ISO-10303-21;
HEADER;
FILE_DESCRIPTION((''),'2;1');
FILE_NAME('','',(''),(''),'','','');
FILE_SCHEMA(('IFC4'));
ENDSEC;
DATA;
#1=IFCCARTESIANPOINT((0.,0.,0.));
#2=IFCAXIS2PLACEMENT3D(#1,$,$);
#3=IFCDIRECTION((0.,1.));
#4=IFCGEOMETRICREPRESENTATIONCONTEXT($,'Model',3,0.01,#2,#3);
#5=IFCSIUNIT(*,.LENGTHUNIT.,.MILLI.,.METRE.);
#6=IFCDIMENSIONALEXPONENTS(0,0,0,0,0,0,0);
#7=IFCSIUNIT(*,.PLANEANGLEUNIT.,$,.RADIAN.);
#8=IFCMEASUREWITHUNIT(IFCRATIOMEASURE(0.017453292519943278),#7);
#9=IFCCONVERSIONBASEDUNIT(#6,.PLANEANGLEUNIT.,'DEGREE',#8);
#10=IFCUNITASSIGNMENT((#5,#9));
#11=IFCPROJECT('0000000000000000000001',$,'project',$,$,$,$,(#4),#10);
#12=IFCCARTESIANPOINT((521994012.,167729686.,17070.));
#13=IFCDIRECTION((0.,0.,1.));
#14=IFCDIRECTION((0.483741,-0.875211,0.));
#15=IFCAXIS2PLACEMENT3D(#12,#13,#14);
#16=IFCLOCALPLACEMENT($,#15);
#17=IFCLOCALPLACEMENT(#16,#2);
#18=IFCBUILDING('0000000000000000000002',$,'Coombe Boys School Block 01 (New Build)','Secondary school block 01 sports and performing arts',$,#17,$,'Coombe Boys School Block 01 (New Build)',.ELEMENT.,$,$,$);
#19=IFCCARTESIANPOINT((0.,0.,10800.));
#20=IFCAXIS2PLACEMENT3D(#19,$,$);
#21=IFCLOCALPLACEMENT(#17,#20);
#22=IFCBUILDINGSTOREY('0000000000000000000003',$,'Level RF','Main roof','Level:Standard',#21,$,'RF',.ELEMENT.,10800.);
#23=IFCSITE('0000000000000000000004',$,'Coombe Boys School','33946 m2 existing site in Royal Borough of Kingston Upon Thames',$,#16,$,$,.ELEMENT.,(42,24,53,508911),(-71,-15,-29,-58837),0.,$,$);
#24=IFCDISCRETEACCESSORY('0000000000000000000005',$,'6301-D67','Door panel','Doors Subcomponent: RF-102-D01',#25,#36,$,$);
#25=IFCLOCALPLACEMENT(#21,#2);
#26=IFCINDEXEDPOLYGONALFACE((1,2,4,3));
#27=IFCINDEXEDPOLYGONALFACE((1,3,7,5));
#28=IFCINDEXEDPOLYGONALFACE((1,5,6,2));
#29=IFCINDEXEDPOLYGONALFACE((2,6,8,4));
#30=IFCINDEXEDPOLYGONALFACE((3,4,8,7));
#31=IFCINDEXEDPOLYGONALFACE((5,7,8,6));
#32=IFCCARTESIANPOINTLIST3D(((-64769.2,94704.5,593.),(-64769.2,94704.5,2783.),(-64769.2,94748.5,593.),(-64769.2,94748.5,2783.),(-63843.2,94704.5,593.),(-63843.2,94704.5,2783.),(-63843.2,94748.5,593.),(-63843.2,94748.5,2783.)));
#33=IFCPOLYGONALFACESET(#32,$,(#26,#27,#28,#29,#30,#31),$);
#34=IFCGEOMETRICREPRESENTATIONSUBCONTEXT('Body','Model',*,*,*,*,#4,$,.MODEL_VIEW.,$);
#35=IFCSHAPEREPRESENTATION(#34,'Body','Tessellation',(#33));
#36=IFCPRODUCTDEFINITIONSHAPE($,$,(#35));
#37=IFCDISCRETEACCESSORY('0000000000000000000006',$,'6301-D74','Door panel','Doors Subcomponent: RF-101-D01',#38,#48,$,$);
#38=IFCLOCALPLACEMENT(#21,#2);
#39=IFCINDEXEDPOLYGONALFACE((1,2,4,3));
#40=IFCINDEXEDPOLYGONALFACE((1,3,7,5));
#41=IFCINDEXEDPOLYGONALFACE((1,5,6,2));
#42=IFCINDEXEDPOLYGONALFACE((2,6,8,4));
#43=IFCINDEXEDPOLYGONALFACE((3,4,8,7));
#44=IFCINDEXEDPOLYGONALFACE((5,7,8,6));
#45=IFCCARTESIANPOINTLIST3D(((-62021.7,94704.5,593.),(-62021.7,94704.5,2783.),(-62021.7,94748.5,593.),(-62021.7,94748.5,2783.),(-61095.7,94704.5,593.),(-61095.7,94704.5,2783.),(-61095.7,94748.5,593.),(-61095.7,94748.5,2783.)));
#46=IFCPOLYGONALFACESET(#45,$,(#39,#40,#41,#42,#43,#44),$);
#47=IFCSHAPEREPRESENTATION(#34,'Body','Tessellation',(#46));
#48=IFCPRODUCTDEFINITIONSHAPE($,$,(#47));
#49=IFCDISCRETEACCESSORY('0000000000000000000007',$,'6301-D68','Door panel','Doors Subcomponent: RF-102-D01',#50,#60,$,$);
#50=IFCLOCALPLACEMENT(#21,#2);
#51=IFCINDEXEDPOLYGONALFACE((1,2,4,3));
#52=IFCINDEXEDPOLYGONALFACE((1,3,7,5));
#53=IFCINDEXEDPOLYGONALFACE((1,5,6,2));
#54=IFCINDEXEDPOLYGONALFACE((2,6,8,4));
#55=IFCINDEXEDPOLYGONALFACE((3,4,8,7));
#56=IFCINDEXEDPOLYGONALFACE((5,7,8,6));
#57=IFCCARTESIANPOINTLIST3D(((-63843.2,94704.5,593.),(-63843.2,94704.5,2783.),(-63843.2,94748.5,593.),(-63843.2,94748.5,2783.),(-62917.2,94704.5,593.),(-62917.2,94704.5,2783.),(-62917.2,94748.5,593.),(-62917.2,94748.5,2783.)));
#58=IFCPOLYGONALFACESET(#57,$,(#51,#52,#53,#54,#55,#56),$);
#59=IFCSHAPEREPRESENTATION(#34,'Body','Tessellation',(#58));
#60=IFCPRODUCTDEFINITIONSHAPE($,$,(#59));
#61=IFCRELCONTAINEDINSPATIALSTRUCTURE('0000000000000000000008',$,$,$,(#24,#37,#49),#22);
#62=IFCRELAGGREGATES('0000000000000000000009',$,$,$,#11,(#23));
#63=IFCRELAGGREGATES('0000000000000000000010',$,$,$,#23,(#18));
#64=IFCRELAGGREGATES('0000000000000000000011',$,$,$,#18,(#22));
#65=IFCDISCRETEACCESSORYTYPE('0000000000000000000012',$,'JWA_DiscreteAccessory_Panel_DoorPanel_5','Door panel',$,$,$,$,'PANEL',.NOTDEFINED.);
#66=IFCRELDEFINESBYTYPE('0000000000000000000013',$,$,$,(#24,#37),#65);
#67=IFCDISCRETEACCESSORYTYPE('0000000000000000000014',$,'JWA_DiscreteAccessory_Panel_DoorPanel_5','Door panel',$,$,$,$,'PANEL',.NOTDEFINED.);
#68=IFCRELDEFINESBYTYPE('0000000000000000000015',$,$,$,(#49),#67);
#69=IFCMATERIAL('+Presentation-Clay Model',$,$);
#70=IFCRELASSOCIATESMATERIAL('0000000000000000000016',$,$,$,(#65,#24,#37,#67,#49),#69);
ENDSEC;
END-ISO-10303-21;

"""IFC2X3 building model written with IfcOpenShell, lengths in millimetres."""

from ifc_helpers import new_model, entity, si_unit, converted_unit, direction, frame, origin, origin_2d_with_axis, place, context, subcontext, project, spatial, rectangle, extrude, source, transform, mapped, material, type_object, type_shapes, element, save


model = new_model("IFC2X3")

# Units and contexts
model_context = context("Model", 3, precision=0.01, world=origin(), true_north=direction((0.0, 1.0)))
body_context = subcontext(model_context, "Body", "Model", "MODEL_VIEW")
ifc_project = project(units=[si_unit("LENGTHUNIT", "METRE", prefix="MILLI"), converted_unit("PLANEANGLEUNIT", "DEGREE", entity("IfcRatioMeasure", 0.017453292519943278), si_unit("PLANEANGLEUNIT", "RADIAN"), dimensions=[0, 0, 0, 0, 0, 0, 0])], contexts=[model_context])

# Site, building, storey
site_placement = place(None, frame((521994012.0, 167729686.0, 17070.0), z_axis=(0.0, 0.0, 1.0), x_axis=(0.483741, -0.875211, 0.0)))
site = spatial("IfcSite", under=ifc_project, at=site_placement, Name="Coombe Boys School", Description="33946 m2 existing site in Royal Borough of Kingston Upon Thames", CompositionType="ELEMENT", RefLatitude=(42, 24, 53, 508911), RefLongitude=(-71, -15, -29, -58837), RefElevation=0.0)
building_placement = place(site_placement, origin())
building = spatial("IfcBuilding", under=site, at=building_placement, Name="Coombe Boys School Block 01 (New Build)", Description="Secondary school block 01 sports and performing arts", LongName="Coombe Boys School Block 01 (New Build)", CompositionType="ELEMENT")
storey_placement = place(building_placement, frame((0.0, 0.0, 10800.0)))
storey = spatial("IfcBuildingStorey", under=building, at=storey_placement, Name="Level RF", Description="Main roof", ObjectType="Level:Standard", LongName="RF", CompositionType="ELEMENT", Elevation=10800.0)

# Discrete accessories
ifc_material_1 = material(Name="+Presentation-Clay Model")
discrete_accessory_type_1 = type_object("IfcDiscreteAccessoryType", Name="JWA_DiscreteAccessory_Panel_DoorPanel_5", Description="Door panel", ElementType="PANEL", material=ifc_material_1)
shared_shape_1 = source(origin(), body_context, "Body", "SweptSolid", [
    extrude(rectangle(XDim=926.0, YDim=44.0, at=origin_2d_with_axis()), frame((0.0, -22.0, 10.0)), (0.0, 0.0, 1.0), 2190.0),
])
type_shapes(discrete_accessory_type_1, [shared_shape_1])
discrete_accessory_1_placement = place(storey_placement, frame((-64306.2, 94704.5, 583.0), z_axis=(0.0, 0.0, 1.0), x_axis=(-1.0, 0.0, 0.0)))
element("IfcDiscreteAccessory", 1, at=discrete_accessory_1_placement, inside=storey, type_object=discrete_accessory_type_1, material=ifc_material_1, Name="6301-D67", Description="Door panel", ObjectType="Doors Subcomponent: RF-102-D01", context=body_context, shape_type="MappedRepresentation", body=[
    mapped(shared_shape_1, transform((0.0, 0.0, 0.0), scale=1.0)),
])
discrete_accessory_2_placement = place(storey_placement, frame((-61558.7, 94704.5, 583.0), z_axis=(0.0, 0.0, 1.0), x_axis=(-1.0, 0.0, 0.0)))
element("IfcDiscreteAccessory", 2, at=discrete_accessory_2_placement, inside=storey, type_object=discrete_accessory_type_1, material=ifc_material_1, Name="6301-D74", Description="Door panel", ObjectType="Doors Subcomponent: RF-101-D01", context=body_context, shape_type="MappedRepresentation", body=[
    mapped(shared_shape_1, transform((0.0, 0.0, 0.0), scale=1.0)),
])
discrete_accessory_type_2 = type_object("IfcDiscreteAccessoryType", Name="JWA_DiscreteAccessory_Panel_DoorPanel_5", Description="Door panel", ElementType="PANEL", material=ifc_material_1)
shared_shape_2 = source(origin(), body_context, "Body", "SweptSolid", [
    extrude(rectangle(XDim=44.0, YDim=926.0, at=origin_2d_with_axis()), frame((0.0, 22.0, 10.0), z_axis=(0.0, 0.0, 1.0), x_axis=(0.0, -1.0, 0.0)), (0.0, 0.0, 1.0), 2190.0),
])
type_shapes(discrete_accessory_type_2, [shared_shape_2])
discrete_accessory_3_placement = place(storey_placement, frame((-63380.2, 94704.5, 583.0)))
element("IfcDiscreteAccessory", 3, at=discrete_accessory_3_placement, inside=storey, type_object=discrete_accessory_type_2, material=ifc_material_1, Name="6301-D68", Description="Door panel", ObjectType="Doors Subcomponent: RF-102-D01", context=body_context, shape_type="MappedRepresentation", body=[
    mapped(shared_shape_2, transform((0.0, 0.0, 0.0), scale=1.0)),
])

save(model, "model.ifc")
